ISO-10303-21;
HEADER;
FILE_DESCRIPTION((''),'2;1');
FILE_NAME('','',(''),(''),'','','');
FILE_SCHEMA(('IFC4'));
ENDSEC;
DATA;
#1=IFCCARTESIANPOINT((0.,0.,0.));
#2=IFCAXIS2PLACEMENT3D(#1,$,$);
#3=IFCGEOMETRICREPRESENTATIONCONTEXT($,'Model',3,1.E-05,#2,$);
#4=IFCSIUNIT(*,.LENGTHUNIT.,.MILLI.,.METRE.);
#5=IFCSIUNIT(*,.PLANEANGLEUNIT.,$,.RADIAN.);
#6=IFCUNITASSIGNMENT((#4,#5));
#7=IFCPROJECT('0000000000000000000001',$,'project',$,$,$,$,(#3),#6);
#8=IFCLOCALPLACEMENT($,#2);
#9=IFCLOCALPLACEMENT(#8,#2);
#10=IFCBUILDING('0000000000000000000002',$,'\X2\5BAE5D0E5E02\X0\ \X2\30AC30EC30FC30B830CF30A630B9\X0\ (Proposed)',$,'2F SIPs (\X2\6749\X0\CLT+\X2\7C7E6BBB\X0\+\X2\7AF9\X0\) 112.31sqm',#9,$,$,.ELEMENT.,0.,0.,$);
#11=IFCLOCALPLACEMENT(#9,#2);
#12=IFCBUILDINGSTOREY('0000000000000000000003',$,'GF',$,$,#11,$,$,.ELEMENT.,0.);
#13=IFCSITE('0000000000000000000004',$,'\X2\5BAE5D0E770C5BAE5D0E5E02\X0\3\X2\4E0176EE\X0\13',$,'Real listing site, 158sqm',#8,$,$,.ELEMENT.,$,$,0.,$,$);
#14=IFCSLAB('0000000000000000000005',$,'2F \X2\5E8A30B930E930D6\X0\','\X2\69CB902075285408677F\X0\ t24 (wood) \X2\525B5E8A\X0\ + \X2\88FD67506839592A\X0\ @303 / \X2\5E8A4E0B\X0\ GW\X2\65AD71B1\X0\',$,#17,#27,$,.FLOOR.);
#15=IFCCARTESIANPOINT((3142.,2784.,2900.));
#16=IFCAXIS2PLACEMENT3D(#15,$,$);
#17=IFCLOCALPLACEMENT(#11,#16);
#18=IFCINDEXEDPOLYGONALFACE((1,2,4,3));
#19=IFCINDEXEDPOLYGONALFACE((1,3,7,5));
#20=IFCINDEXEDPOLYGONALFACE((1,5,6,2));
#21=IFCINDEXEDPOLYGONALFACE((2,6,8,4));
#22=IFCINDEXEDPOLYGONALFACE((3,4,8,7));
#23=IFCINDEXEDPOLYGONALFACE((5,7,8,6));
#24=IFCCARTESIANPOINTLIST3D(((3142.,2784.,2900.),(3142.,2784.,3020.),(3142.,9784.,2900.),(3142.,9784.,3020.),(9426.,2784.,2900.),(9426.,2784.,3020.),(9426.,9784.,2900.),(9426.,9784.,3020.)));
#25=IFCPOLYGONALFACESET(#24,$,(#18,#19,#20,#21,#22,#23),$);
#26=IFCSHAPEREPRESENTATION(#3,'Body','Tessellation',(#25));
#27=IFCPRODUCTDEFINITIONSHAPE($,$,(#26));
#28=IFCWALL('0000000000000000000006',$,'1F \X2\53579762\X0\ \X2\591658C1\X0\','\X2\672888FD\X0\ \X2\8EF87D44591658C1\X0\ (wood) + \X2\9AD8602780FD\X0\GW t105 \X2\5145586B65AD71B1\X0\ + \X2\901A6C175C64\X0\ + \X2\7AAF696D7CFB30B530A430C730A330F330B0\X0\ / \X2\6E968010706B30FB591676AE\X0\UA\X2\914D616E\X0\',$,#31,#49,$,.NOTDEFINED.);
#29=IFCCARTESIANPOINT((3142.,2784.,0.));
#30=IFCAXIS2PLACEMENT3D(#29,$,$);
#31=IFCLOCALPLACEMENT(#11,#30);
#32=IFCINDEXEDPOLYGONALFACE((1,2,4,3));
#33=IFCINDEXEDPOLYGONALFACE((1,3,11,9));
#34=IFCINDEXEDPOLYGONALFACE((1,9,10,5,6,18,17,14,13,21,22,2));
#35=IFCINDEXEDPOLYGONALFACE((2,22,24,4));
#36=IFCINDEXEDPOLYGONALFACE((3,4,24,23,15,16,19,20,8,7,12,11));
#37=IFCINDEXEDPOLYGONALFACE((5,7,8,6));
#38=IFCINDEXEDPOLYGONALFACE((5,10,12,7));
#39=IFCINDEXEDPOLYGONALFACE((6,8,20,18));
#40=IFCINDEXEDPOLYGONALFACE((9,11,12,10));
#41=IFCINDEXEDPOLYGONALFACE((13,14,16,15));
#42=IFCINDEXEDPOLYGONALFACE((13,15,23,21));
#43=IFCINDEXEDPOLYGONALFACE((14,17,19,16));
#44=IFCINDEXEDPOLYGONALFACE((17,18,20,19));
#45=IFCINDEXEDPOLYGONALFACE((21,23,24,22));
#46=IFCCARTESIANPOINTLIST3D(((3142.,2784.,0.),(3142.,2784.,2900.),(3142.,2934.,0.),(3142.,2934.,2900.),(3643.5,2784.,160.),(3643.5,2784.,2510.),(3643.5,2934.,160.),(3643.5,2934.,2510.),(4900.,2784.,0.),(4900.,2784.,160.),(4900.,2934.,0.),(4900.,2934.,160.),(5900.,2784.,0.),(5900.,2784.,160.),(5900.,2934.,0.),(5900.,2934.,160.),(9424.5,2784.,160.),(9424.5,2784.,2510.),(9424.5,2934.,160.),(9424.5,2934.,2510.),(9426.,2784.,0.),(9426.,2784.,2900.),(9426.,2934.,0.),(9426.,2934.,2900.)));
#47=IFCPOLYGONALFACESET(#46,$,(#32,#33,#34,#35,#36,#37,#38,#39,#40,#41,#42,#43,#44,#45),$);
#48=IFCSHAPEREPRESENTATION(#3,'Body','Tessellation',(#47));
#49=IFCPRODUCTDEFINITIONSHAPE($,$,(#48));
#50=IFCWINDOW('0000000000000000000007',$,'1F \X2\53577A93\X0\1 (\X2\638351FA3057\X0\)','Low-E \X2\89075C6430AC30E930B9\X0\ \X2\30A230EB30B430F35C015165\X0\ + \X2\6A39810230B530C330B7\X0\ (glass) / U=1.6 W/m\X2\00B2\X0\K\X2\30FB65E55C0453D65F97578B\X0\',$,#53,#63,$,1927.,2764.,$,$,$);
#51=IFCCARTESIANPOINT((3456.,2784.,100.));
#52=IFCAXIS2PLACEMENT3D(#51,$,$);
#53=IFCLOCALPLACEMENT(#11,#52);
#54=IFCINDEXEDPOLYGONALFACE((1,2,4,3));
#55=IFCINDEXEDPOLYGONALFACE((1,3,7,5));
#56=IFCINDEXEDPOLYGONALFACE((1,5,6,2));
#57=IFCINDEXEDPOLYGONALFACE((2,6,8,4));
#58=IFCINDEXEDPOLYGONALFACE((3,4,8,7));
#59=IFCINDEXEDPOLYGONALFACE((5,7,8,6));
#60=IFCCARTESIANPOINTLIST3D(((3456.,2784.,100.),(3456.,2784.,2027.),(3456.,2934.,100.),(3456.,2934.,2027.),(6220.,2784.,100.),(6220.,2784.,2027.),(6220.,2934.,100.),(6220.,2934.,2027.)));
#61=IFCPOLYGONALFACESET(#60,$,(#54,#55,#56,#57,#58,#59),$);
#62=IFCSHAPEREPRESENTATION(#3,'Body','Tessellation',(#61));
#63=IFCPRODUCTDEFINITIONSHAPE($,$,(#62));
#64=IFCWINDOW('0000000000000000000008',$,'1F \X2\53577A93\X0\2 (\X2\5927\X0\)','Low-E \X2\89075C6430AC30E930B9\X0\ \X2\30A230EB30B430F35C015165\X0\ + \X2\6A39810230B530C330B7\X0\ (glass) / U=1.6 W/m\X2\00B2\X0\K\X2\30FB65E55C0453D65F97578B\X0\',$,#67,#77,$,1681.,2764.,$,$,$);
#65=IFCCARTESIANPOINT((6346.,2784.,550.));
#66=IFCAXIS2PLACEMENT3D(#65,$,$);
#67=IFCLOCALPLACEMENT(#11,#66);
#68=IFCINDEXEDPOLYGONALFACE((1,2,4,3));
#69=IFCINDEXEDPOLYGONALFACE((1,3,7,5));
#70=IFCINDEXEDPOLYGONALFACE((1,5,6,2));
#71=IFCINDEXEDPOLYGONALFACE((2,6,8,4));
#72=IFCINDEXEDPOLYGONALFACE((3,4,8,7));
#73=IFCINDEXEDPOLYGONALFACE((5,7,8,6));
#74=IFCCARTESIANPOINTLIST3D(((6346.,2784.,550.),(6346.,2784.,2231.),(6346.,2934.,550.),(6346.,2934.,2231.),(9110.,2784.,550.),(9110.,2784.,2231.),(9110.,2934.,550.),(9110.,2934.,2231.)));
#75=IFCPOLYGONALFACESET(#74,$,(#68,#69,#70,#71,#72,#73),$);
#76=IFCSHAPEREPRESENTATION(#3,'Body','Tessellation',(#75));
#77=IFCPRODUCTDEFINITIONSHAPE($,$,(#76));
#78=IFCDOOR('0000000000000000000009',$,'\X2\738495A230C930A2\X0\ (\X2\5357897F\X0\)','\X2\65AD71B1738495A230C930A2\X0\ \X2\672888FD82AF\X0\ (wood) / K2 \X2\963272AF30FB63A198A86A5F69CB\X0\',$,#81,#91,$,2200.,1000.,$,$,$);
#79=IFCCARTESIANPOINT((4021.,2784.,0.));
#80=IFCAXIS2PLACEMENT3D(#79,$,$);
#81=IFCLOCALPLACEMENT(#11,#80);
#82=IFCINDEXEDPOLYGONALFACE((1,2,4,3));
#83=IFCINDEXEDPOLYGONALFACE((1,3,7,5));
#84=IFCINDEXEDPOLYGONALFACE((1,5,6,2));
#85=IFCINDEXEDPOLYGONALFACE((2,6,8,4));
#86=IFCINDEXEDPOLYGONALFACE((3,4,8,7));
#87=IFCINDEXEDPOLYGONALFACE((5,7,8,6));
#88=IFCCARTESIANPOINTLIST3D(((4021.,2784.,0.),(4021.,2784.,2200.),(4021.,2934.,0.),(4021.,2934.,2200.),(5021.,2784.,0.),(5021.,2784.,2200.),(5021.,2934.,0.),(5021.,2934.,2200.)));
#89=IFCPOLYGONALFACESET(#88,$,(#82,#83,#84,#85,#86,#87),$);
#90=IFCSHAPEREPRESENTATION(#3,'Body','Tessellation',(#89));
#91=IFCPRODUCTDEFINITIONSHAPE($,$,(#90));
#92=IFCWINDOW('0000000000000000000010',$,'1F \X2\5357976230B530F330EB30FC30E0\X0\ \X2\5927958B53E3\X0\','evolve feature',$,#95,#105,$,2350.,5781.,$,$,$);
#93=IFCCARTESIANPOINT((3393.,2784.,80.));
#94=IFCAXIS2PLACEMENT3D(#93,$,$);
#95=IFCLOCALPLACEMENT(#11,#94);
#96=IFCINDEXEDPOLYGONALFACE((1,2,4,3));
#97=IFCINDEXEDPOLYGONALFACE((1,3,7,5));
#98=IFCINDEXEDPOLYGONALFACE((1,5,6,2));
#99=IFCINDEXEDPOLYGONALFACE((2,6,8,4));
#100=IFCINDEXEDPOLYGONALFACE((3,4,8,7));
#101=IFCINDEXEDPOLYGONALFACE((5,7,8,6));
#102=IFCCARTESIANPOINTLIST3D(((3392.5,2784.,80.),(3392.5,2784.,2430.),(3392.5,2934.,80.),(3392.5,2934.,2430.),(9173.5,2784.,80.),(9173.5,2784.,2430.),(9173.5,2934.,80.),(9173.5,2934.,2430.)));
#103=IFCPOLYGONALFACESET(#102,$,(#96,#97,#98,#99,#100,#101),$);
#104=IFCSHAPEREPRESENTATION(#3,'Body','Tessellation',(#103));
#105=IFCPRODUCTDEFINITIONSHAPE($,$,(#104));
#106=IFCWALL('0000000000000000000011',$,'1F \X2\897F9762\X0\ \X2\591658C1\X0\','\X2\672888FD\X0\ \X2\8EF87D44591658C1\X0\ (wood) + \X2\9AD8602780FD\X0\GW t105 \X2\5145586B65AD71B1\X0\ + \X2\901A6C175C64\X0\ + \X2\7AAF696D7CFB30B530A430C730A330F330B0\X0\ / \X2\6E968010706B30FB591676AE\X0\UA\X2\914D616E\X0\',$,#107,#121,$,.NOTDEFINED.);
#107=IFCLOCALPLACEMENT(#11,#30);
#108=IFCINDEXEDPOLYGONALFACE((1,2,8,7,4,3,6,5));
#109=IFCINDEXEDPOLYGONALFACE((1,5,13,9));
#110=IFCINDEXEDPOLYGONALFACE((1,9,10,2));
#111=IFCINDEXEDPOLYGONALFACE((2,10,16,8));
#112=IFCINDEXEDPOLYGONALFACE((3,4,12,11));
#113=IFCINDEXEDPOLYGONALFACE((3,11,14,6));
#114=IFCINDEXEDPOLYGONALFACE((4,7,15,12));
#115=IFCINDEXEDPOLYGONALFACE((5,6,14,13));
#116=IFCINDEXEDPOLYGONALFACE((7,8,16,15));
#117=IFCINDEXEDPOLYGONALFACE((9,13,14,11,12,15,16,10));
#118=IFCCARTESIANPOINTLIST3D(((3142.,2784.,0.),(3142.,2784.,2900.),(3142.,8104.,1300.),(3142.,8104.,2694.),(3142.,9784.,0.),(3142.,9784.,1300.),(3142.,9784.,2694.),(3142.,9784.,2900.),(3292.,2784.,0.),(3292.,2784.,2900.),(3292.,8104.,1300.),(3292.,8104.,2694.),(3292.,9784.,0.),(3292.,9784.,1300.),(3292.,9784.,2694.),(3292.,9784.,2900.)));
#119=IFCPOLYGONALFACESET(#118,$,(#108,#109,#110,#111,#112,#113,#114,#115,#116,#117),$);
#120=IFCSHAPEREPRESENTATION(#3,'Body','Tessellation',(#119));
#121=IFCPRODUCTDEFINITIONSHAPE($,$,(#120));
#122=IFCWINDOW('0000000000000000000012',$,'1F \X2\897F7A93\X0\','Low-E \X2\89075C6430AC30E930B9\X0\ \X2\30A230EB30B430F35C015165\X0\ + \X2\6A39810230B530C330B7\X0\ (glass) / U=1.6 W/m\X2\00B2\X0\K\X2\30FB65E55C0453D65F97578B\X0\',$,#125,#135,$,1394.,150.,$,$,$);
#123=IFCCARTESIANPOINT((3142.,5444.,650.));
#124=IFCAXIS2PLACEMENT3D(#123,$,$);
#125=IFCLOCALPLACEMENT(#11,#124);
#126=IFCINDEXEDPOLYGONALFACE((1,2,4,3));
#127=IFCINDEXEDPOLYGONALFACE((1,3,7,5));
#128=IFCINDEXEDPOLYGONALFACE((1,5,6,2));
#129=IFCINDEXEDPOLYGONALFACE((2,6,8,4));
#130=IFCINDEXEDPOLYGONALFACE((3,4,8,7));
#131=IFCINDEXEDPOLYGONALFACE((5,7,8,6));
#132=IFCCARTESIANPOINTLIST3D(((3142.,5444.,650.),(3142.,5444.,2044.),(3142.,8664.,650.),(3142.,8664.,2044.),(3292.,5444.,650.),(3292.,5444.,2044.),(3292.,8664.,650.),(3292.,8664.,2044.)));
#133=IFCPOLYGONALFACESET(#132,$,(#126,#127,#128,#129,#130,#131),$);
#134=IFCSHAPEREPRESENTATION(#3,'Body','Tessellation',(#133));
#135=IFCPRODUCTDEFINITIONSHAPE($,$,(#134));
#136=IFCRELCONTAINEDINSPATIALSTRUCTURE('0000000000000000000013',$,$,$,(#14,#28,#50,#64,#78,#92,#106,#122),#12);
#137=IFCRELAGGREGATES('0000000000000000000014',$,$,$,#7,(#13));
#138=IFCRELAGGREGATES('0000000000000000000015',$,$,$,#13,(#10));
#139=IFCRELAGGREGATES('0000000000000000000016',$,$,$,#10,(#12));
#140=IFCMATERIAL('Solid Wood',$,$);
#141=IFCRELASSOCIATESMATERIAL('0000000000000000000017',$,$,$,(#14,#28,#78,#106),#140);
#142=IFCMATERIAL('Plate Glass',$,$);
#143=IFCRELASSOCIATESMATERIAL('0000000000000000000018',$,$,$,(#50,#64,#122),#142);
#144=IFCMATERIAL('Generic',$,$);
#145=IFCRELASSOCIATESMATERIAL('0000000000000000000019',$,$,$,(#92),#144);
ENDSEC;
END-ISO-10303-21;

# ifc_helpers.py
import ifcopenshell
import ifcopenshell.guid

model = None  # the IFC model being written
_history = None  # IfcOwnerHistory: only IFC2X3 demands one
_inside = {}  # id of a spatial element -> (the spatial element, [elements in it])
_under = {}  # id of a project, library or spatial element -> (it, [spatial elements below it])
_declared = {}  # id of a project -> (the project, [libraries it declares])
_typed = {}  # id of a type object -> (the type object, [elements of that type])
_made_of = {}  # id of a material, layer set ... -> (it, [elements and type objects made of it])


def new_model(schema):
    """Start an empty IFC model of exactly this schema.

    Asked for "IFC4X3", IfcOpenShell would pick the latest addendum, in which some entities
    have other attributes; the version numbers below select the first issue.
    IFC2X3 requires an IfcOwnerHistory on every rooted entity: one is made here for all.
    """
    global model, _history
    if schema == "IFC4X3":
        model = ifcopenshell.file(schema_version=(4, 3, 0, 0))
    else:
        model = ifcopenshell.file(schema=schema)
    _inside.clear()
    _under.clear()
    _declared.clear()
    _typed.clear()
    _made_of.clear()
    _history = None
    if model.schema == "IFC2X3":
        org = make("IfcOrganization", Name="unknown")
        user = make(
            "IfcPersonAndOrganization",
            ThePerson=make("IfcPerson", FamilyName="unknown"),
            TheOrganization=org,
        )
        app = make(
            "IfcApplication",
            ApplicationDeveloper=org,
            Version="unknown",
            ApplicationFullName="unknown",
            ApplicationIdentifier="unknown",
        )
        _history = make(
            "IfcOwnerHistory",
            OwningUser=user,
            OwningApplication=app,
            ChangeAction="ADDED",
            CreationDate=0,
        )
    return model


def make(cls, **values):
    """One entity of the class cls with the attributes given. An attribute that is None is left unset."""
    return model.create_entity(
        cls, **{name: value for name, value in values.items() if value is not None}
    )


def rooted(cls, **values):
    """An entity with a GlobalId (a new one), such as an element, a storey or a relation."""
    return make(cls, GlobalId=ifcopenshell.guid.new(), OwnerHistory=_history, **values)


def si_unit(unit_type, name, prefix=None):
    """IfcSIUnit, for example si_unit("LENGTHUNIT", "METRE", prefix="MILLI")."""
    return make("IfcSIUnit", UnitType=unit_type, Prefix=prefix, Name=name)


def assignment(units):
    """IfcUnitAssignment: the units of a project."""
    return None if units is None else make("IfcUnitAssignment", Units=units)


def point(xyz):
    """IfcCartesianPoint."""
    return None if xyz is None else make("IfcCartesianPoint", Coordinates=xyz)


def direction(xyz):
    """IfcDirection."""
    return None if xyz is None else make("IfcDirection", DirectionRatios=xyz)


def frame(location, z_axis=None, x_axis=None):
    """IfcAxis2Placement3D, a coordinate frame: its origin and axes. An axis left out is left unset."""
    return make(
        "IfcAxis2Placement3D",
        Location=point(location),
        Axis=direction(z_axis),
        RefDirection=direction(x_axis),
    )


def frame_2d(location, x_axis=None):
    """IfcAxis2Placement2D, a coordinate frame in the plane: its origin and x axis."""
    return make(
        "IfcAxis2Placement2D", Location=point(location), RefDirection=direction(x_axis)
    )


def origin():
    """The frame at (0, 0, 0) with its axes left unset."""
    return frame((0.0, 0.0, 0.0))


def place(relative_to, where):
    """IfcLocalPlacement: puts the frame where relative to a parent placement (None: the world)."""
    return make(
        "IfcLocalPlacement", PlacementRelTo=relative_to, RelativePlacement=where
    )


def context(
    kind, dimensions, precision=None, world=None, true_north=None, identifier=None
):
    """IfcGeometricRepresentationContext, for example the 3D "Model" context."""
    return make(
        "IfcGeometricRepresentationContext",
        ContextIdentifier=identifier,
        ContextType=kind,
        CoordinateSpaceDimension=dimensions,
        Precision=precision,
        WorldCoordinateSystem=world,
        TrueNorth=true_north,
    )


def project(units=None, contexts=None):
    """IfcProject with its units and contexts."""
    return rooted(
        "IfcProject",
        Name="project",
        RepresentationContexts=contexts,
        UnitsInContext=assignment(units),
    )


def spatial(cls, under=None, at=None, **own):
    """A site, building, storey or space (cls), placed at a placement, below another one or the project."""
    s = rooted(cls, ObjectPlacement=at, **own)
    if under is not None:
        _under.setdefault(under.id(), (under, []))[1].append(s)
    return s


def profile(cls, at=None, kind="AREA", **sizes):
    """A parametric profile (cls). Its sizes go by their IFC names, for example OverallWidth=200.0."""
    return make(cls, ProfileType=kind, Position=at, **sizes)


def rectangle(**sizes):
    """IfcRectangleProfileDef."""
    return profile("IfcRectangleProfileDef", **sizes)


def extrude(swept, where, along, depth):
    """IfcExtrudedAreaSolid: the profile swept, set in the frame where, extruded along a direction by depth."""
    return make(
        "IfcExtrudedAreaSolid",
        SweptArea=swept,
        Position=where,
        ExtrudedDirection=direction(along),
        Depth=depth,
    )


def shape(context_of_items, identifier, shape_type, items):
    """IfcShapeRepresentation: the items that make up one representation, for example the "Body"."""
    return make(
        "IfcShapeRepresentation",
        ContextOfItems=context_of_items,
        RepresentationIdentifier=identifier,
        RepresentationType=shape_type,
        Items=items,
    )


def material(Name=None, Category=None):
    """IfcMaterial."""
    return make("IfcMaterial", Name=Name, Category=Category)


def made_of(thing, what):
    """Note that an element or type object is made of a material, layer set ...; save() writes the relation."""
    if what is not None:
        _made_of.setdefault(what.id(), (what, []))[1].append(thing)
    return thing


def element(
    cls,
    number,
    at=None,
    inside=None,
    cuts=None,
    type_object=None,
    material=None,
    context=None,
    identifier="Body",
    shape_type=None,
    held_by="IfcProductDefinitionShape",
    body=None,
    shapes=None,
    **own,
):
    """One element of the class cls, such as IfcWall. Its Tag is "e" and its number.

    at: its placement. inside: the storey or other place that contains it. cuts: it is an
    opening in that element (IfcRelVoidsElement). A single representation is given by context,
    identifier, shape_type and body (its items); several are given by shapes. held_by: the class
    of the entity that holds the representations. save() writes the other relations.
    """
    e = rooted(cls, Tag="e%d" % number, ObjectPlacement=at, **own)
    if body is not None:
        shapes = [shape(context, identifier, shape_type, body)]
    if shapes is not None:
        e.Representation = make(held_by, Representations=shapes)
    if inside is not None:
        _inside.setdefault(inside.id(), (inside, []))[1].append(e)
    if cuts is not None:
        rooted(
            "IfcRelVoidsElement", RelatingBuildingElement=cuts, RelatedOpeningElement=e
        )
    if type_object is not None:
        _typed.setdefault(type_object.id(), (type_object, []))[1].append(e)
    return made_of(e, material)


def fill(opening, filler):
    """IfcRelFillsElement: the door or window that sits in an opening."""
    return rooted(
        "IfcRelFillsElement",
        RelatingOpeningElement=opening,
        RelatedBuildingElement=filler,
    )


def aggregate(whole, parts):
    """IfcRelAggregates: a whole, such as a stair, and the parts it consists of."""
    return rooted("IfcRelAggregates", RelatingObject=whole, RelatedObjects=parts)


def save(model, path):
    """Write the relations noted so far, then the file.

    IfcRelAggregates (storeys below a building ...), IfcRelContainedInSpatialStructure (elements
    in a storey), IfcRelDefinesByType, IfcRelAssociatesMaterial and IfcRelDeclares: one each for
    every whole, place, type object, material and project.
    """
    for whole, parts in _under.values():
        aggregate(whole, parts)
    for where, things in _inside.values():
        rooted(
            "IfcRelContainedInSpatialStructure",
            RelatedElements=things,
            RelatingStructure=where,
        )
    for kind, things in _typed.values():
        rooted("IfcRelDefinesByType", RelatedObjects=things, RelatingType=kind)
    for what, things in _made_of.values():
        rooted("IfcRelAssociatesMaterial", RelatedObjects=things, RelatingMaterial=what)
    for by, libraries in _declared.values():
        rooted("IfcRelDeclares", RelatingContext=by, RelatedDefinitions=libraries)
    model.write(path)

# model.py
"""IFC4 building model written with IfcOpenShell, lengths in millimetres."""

from ifc_helpers import new_model, si_unit, frame, frame_2d, origin, place, context, project, spatial, rectangle, extrude, material, element, fill, save


model = new_model("IFC4")

# Units and contexts
model_context = context("Model", 3, precision=1e-05, world=origin())
ifc_project = project(units=[si_unit("LENGTHUNIT", "METRE", prefix="MILLI"), si_unit("PLANEANGLEUNIT", "RADIAN")], contexts=[model_context])

# Site, building, storey
site_placement = place(None, origin())
site = spatial("IfcSite", under=ifc_project, at=site_placement, Name="宮崎県宮崎市3丁目13", ObjectType="Real listing site, 158sqm", CompositionType="ELEMENT", RefElevation=0.0)
building_placement = place(site_placement, origin())
building = spatial("IfcBuilding", under=site, at=building_placement, Name="宮崎市 ガレージハウス (Proposed)", ObjectType="2F SIPs (杉CLT+籾殻+竹) 112.31sqm", CompositionType="ELEMENT", ElevationOfRefHeight=0.0, ElevationOfTerrain=0.0)
storey_placement = place(building_placement, origin())
storey = spatial("IfcBuildingStorey", under=building, at=storey_placement, Name="GF", CompositionType="ELEMENT", Elevation=0.0)

# Slab
ifc_material_1 = material(Name="Solid Wood")
slab_1_placement = place(storey_placement, frame((3142.0, 2784.0, 2900.0)))
element("IfcSlab", 1, at=slab_1_placement, inside=storey, material=ifc_material_1, Name="2F 床スラブ", Description="構造用合板 t24 (wood) 剛床 + 製材根太 @303 / 床下 GW断熱", PredefinedType="FLOOR", context=model_context, shape_type="SweptSolid", body=[
    extrude(rectangle(XDim=6284.0, YDim=7000.0, at=frame_2d((3142.0, 3500.0))), frame((3142.0, 2784.0, 2900.0)), (0.0, 0.0, 1.0), 120.0),
])
ifc_material_2 = material(Name="Generic")

# Wall, openings, windows, door
wall_1_placement = place(storey_placement, frame((3142.0, 2784.0, 0.0)))
wall_1 = element("IfcWall", 2, at=wall_1_placement, inside=storey, material=ifc_material_1, Name="1F 南面 外壁", Description="木製 軸組外壁 (wood) + 高性能GW t105 充填断熱 + 通気層 + 窯業系サイディング / 準耐火・外皮UA配慮", PredefinedType="NOTDEFINED", context=model_context, shape_type="SweptSolid", body=[
    extrude(rectangle(XDim=6284.0, YDim=150.0, at=frame_2d((3142.0, 75.0))), frame((3142.0, 2784.0, 0.0)), (0.0, 0.0, 1.0), 2900.0),
])
opening_1_placement = place(storey_placement, frame((3456.0, 2784.0, 100.0)))
opening_1 = element("IfcOpeningElement", 3, at=opening_1_placement, cuts=wall_1, PredefinedType="NOTDEFINED", context=model_context, shape_type="SweptSolid", body=[
    extrude(rectangle(XDim=2764.0, YDim=150.0, at=frame_2d((1382.0, 75.0))), frame((3456.0, 2784.0, 100.0)), (0.0, 0.0, 1.0), 1927.0),
])
opening_2_placement = place(storey_placement, frame((6346.0, 2784.0, 550.0)))
opening_2 = element("IfcOpeningElement", 4, at=opening_2_placement, cuts=wall_1, PredefinedType="NOTDEFINED", context=model_context, shape_type="SweptSolid", body=[
    extrude(rectangle(XDim=2764.0, YDim=150.0, at=frame_2d((1382.0, 75.0))), frame((6346.0, 2784.0, 550.0)), (0.0, 0.0, 1.0), 1681.0),
])
opening_3_placement = place(storey_placement, frame((4021.0, 2784.0, 0.0)))
opening_3 = element("IfcOpeningElement", 5, at=opening_3_placement, cuts=wall_1, PredefinedType="NOTDEFINED", context=model_context, shape_type="SweptSolid", body=[
    extrude(rectangle(XDim=1000.0, YDim=150.0, at=frame_2d((500.0, 75.0))), frame((4021.0, 2784.0, 0.0)), (0.0, 0.0, 1.0), 2200.0),
])
opening_4_placement = place(storey_placement, frame((3393.0, 2784.0, 80.0)))
opening_4 = element("IfcOpeningElement", 6, at=opening_4_placement, cuts=wall_1, PredefinedType="NOTDEFINED", context=model_context, shape_type="SweptSolid", body=[
    extrude(rectangle(XDim=5781.0, YDim=150.0, at=frame_2d((2890.0, 75.0))), frame((3393.0, 2784.0, 80.0)), (0.0, 0.0, 1.0), 2350.0),
])
ifc_material_3 = material(Name="Plate Glass")
window_1_placement = place(storey_placement, frame((3456.0, 2784.0, 100.0)))
window_1 = element("IfcWindow", 7, at=window_1_placement, inside=storey, material=ifc_material_3, Name="1F 南窓1 (掃出し)", Description="Low-E 複層ガラス アルゴン封入 + 樹脂サッシ (glass) / U=1.6 W/m²K・日射取得型", OverallHeight=1927.0, OverallWidth=2764.0, context=model_context, shape_type="SweptSolid", body=[
    extrude(rectangle(XDim=2764.0, YDim=150.0, at=frame_2d((1382.0, 75.0))), frame((3456.0, 2784.0, 100.0)), (0.0, 0.0, 1.0), 1927.0),
])
fill(opening_1, window_1)
window_2_placement = place(storey_placement, frame((6346.0, 2784.0, 550.0)))
window_2 = element("IfcWindow", 8, at=window_2_placement, inside=storey, material=ifc_material_3, Name="1F 南窓2 (大)", Description="Low-E 複層ガラス アルゴン封入 + 樹脂サッシ (glass) / U=1.6 W/m²K・日射取得型", OverallHeight=1681.0, OverallWidth=2764.0, context=model_context, shape_type="SweptSolid", body=[
    extrude(rectangle(XDim=2764.0, YDim=150.0, at=frame_2d((1382.0, 75.0))), frame((6346.0, 2784.0, 550.0)), (0.0, 0.0, 1.0), 1681.0),
])
fill(opening_2, window_2)
door_placement = place(storey_placement, frame((4021.0, 2784.0, 0.0)))
door = element("IfcDoor", 9, at=door_placement, inside=storey, material=ifc_material_1, Name="玄関ドア (南西)", Description="断熱玄関ドア 木製芯 (wood) / K2 防犯・採風機構", OverallHeight=2200.0, OverallWidth=1000.0, context=model_context, shape_type="SweptSolid", body=[
    extrude(rectangle(XDim=1000.0, YDim=150.0, at=frame_2d((500.0, 75.0))), frame((4021.0, 2784.0, 0.0)), (0.0, 0.0, 1.0), 2200.0),
])
fill(opening_3, door)
window_3_placement = place(storey_placement, frame((3393.0, 2784.0, 80.0)))
window_3 = element("IfcWindow", 10, at=window_3_placement, inside=storey, material=ifc_material_2, Name="1F 南面サンルーム 大開口", Description="evolve feature", OverallHeight=2350.0, OverallWidth=5781.0, context=model_context, shape_type="SweptSolid", body=[
    extrude(rectangle(XDim=5781.0, YDim=150.0, at=frame_2d((2890.0, 75.0))), frame((3393.0, 2784.0, 80.0)), (0.0, 0.0, 1.0), 2350.0),
])
fill(opening_4, window_3)

# Wall, opening, window
wall_2_placement = place(storey_placement, frame((3142.0, 2784.0, 0.0)))
wall_2 = element("IfcWall", 11, at=wall_2_placement, inside=storey, material=ifc_material_1, Name="1F 西面 外壁", Description="木製 軸組外壁 (wood) + 高性能GW t105 充填断熱 + 通気層 + 窯業系サイディング / 準耐火・外皮UA配慮", PredefinedType="NOTDEFINED", context=model_context, shape_type="SweptSolid", body=[
    extrude(rectangle(XDim=150.0, YDim=7000.0, at=frame_2d((75.0, 3500.0))), frame((3142.0, 2784.0, 0.0)), (0.0, 0.0, 1.0), 2900.0),
])
opening_5_placement = place(storey_placement, frame((3142.0, 5444.0, 650.0)))
opening_5 = element("IfcOpeningElement", 12, at=opening_5_placement, cuts=wall_2, PredefinedType="NOTDEFINED", context=model_context, shape_type="SweptSolid", body=[
    extrude(rectangle(XDim=150.0, YDim=3220.0, at=frame_2d((75.0, 1610.0))), frame((3142.0, 5444.0, 650.0)), (0.0, 0.0, 1.0), 1394.0),
])
window_4_placement = place(storey_placement, frame((3142.0, 5444.0, 650.0)))
window_4 = element("IfcWindow", 13, at=window_4_placement, inside=storey, material=ifc_material_3, Name="1F 西窓", Description="Low-E 複層ガラス アルゴン封入 + 樹脂サッシ (glass) / U=1.6 W/m²K・日射取得型", OverallHeight=1394.0, OverallWidth=150.0, context=model_context, shape_type="SweptSolid", body=[
    extrude(rectangle(XDim=150.0, YDim=3220.0, at=frame_2d((75.0, 1610.0))), frame((3142.0, 5444.0, 650.0)), (0.0, 0.0, 1.0), 1394.0),
])
fill(opening_5, window_4)

save(model, "model.ifc")
